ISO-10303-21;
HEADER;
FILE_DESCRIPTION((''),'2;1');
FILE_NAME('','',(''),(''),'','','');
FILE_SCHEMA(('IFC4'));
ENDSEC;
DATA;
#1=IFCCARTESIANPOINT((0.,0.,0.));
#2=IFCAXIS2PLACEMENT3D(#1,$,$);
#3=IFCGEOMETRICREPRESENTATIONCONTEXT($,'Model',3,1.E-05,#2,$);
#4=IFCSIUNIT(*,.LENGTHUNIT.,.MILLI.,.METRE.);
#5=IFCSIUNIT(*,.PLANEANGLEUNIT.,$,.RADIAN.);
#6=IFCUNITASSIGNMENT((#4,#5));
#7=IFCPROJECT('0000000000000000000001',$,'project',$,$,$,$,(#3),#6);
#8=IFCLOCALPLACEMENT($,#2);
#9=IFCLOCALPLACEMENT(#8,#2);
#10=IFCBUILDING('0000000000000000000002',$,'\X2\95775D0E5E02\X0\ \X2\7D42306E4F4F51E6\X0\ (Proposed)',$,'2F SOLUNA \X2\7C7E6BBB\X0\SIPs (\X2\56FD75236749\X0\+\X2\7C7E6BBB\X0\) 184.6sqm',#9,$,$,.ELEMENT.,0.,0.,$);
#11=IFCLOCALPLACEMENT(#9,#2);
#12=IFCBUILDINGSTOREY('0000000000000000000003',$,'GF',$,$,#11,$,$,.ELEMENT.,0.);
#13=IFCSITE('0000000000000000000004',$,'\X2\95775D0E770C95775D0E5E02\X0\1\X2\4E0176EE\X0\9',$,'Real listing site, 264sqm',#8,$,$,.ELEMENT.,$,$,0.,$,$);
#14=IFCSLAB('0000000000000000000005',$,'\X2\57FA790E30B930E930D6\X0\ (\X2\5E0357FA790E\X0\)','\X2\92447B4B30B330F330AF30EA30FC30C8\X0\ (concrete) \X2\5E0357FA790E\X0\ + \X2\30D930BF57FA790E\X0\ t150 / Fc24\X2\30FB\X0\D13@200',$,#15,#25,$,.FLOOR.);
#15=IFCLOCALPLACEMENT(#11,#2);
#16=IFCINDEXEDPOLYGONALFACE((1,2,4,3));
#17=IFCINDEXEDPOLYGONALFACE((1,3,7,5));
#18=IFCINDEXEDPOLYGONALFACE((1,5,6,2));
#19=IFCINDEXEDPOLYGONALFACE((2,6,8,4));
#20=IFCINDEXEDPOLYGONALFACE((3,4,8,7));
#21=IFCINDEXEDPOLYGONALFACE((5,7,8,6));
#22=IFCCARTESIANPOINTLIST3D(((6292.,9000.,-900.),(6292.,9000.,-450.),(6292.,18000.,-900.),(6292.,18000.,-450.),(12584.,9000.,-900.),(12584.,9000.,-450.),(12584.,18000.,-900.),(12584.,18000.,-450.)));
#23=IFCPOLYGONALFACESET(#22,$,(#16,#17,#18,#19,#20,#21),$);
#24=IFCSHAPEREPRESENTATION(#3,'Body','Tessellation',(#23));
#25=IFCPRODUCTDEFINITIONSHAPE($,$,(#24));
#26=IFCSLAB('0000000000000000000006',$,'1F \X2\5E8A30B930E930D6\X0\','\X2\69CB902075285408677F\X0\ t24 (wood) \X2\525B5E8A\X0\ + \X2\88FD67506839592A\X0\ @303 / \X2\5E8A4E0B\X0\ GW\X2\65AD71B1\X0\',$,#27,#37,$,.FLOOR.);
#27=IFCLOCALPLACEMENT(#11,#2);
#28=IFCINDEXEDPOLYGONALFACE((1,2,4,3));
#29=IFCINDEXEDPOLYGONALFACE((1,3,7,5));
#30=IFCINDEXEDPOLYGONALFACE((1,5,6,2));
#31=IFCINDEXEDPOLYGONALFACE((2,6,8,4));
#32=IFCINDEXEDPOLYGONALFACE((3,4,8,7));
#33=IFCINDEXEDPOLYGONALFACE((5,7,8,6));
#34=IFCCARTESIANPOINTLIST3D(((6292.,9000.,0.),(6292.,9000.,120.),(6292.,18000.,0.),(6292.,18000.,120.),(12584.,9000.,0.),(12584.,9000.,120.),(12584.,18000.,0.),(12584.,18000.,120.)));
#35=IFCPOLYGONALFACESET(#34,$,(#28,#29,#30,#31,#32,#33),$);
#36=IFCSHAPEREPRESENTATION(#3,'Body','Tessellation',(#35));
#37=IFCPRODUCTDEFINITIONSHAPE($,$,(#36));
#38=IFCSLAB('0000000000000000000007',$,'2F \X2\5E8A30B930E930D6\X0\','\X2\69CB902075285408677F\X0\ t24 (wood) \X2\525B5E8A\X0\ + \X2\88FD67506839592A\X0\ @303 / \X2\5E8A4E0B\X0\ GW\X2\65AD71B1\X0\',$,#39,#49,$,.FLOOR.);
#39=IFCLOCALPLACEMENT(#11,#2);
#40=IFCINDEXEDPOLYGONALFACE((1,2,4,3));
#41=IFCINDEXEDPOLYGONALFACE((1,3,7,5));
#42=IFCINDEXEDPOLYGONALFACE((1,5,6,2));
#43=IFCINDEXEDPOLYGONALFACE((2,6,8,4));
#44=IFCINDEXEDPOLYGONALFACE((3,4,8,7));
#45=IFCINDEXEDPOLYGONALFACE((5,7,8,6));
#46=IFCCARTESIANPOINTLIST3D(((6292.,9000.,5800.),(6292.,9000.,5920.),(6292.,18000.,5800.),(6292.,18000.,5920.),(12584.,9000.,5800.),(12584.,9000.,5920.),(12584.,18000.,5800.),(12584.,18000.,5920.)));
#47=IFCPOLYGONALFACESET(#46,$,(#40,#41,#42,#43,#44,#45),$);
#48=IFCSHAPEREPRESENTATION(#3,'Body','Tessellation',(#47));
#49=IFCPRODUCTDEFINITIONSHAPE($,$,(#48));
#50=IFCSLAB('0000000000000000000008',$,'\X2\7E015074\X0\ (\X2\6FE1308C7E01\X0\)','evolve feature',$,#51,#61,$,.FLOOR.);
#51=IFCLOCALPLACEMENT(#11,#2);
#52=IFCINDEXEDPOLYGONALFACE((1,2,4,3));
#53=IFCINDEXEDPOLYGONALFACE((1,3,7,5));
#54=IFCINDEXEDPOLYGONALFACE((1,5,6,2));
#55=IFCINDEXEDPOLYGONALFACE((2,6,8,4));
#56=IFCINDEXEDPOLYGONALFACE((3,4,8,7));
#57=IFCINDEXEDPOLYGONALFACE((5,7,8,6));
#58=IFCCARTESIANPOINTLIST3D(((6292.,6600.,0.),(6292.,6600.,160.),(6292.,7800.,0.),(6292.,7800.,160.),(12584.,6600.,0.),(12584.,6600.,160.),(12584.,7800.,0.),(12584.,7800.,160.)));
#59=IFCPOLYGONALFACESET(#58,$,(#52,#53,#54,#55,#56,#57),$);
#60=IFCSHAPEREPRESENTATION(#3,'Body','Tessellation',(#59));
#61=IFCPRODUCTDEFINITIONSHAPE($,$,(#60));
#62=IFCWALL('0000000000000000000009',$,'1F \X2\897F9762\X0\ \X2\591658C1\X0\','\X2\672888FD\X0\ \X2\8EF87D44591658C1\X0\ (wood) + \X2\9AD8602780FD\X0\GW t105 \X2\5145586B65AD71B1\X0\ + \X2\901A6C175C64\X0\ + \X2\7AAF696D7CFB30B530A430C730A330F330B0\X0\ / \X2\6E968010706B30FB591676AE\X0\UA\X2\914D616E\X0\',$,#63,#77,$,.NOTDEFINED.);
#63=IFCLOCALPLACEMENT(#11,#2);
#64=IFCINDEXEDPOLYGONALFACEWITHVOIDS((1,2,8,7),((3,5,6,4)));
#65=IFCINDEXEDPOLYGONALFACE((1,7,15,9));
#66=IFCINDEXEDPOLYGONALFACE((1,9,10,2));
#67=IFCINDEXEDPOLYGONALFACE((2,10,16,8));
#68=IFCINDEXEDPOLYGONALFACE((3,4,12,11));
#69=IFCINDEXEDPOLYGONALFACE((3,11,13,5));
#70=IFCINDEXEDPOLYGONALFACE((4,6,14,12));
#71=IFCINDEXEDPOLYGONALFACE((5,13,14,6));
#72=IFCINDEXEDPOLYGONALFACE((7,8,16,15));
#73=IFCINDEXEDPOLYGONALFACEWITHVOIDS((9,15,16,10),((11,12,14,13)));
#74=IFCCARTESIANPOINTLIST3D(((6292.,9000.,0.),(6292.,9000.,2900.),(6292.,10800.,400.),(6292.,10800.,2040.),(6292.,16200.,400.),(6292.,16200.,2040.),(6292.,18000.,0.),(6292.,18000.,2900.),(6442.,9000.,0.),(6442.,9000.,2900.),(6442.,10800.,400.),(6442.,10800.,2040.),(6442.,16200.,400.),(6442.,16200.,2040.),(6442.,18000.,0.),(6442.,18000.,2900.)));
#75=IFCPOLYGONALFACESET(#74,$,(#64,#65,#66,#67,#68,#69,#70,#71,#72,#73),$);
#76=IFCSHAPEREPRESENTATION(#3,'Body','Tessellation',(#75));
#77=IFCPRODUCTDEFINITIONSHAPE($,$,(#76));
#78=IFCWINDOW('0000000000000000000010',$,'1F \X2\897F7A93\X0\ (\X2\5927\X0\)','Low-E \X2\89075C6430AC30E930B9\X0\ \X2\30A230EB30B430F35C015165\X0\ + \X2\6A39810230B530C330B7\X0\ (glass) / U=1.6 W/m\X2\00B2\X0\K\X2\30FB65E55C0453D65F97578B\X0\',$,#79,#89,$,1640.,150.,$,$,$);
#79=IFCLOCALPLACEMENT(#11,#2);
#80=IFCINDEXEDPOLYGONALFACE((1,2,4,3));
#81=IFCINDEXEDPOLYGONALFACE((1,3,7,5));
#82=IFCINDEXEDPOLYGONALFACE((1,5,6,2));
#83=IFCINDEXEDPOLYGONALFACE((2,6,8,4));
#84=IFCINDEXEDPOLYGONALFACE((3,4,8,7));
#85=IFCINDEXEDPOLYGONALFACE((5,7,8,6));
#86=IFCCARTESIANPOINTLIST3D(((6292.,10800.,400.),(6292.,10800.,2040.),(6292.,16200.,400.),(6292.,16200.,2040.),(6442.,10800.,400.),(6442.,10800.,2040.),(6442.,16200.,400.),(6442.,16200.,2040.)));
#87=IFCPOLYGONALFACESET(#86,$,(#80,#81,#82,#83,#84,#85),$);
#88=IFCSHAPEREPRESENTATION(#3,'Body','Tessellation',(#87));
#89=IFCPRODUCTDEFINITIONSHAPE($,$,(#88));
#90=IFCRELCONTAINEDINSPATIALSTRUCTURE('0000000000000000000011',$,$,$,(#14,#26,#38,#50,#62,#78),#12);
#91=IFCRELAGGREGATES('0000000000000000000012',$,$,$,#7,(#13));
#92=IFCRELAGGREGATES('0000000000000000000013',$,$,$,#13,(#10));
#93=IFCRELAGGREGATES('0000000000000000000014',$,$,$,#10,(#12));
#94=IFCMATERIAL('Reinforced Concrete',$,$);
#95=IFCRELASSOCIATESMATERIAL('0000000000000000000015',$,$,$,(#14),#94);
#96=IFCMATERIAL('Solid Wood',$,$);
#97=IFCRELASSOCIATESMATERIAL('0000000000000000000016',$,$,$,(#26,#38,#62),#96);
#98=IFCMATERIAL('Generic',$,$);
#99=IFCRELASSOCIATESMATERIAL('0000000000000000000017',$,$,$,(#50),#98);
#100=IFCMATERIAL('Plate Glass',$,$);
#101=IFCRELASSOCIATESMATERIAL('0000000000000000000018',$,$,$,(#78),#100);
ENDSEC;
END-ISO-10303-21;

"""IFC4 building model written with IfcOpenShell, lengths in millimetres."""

from ifc_helpers import new_model, si_unit, frame, frame_2d, origin, place, context, project, spatial, rectangle, extrude, material, element, fill, save


model = new_model("IFC4")

# Units and contexts
model_context = context("Model", 3, precision=1e-05, world=origin())
ifc_project = project(units=[si_unit("LENGTHUNIT", "METRE", prefix="MILLI"), si_unit("PLANEANGLEUNIT", "RADIAN")], contexts=[model_context])

# Site, building, storey
site_placement = place(None, origin())
site = spatial("IfcSite", under=ifc_project, at=site_placement, Name="長崎県長崎市1丁目9", ObjectType="Real listing site, 264sqm", CompositionType="ELEMENT", RefElevation=0.0)
building_placement = place(site_placement, origin())
building = spatial("IfcBuilding", under=site, at=building_placement, Name="長崎市 終の住処 (Proposed)", ObjectType="2F SOLUNA 籾殻SIPs (国産杉+籾殻) 184.6sqm", CompositionType="ELEMENT", ElevationOfRefHeight=0.0, ElevationOfTerrain=0.0)
storey_placement = place(building_placement, origin())
storey = spatial("IfcBuildingStorey", under=building, at=storey_placement, Name="GF", CompositionType="ELEMENT", Elevation=0.0)

# Slabs
ifc_material_1 = material(Name="Reinforced Concrete")
slab_1_placement = place(storey_placement, frame((3146.0, 4500.0, -450.0)))
element("IfcSlab", 1, at=slab_1_placement, inside=storey, material=ifc_material_1, Name="基礎スラブ (布基礎)", Description="鉄筋コンクリート (concrete) 布基礎 + ベタ基礎 t150 / Fc24・D13@200", PredefinedType="FLOOR", context=model_context, shape_type="SweptSolid", body=[
    extrude(rectangle(XDim=6292.0, YDim=9000.0, at=frame_2d((3146.0, 4500.0))), frame((3146.0, 4500.0, -450.0)), (0.0, 0.0, 1.0), 450.0),
])
ifc_material_2 = material(Name="Solid Wood")
slab_2_placement = place(storey_placement, frame((3146.0, 4500.0, 0.0)))
element("IfcSlab", 2, at=slab_2_placement, inside=storey, material=ifc_material_2, Name="1F 床スラブ", Description="構造用合板 t24 (wood) 剛床 + 製材根太 @303 / 床下 GW断熱", PredefinedType="FLOOR", context=model_context, shape_type="SweptSolid", body=[
    extrude(rectangle(XDim=6292.0, YDim=9000.0, at=frame_2d((3146.0, 4500.0))), frame((3146.0, 4500.0, 0.0)), (0.0, 0.0, 1.0), 120.0),
])
slab_3_placement = place(storey_placement, frame((3146.0, 4500.0, 2900.0)))
element("IfcSlab", 3, at=slab_3_placement, inside=storey, material=ifc_material_2, Name="2F 床スラブ", Description="構造用合板 t24 (wood) 剛床 + 製材根太 @303 / 床下 GW断熱", PredefinedType="FLOOR", context=model_context, shape_type="SweptSolid", body=[
    extrude(rectangle(XDim=6292.0, YDim=9000.0, at=frame_2d((3146.0, 4500.0))), frame((3146.0, 4500.0, 2900.0)), (0.0, 0.0, 1.0), 120.0),
])
ifc_material_3 = material(Name="Generic")
slab_4_placement = place(storey_placement, frame((3146.0, 3300.0, 0.0)))
element("IfcSlab", 4, at=slab_4_placement, inside=storey, material=ifc_material_3, Name="縁側 (濡れ縁)", Description="evolve feature", PredefinedType="FLOOR", context=model_context, shape_type="SweptSolid", body=[
    extrude(rectangle(XDim=6292.0, YDim=1200.0, at=frame_2d((3146.0, 600.0))), frame((3146.0, 3300.0, 0.0)), (0.0, 0.0, 1.0), 160.0),
])

# Shared definitions
ifc_material_4 = material(Name="Plate Glass")

# Wall, opening, window
wall_1_placement = place(storey_placement, frame((3146.0, 4500.0, 0.0)))
wall_1 = element("IfcWall", 5, at=wall_1_placement, inside=storey, material=ifc_material_2, Name="1F 西面 外壁", Description="木製 軸組外壁 (wood) + 高性能GW t105 充填断熱 + 通気層 + 窯業系サイディング / 準耐火・外皮UA配慮", PredefinedType="NOTDEFINED", context=model_context, shape_type="SweptSolid", body=[
    extrude(rectangle(XDim=150.0, YDim=9000.0, at=frame_2d((75.0, 4500.0))), frame((3146.0, 4500.0, 0.0)), (0.0, 0.0, 1.0), 2900.0),
])
opening_1_placement = place(storey_placement, frame((3146.0, 5400.0, 200.0)))
opening_1 = element("IfcOpeningElement", 6, at=opening_1_placement, cuts=wall_1, PredefinedType="NOTDEFINED", context=model_context, shape_type="SweptSolid", body=[
    extrude(rectangle(XDim=150.0, YDim=5400.0, at=frame_2d((75.0, 2700.0))), frame((3146.0, 5400.0, 200.0)), (0.0, 0.0, 1.0), 1640.0),
])
window_1_placement = place(storey_placement, frame((3146.0, 5400.0, 200.0)))
window_1 = element("IfcWindow", 7, at=window_1_placement, inside=storey, material=ifc_material_4, Name="1F 西窓 (大)", Description="Low-E 複層ガラス アルゴン封入 + 樹脂サッシ (glass) / U=1.6 W/m²K・日射取得型", OverallHeight=1640.0, OverallWidth=150.0, context=model_context, shape_type="SweptSolid", body=[
    extrude(rectangle(XDim=150.0, YDim=5400.0, at=frame_2d((75.0, 2700.0))), frame((3146.0, 5400.0, 200.0)), (0.0, 0.0, 1.0), 1640.0),
])
fill(opening_1, window_1)

save(model, "model.ifc")
